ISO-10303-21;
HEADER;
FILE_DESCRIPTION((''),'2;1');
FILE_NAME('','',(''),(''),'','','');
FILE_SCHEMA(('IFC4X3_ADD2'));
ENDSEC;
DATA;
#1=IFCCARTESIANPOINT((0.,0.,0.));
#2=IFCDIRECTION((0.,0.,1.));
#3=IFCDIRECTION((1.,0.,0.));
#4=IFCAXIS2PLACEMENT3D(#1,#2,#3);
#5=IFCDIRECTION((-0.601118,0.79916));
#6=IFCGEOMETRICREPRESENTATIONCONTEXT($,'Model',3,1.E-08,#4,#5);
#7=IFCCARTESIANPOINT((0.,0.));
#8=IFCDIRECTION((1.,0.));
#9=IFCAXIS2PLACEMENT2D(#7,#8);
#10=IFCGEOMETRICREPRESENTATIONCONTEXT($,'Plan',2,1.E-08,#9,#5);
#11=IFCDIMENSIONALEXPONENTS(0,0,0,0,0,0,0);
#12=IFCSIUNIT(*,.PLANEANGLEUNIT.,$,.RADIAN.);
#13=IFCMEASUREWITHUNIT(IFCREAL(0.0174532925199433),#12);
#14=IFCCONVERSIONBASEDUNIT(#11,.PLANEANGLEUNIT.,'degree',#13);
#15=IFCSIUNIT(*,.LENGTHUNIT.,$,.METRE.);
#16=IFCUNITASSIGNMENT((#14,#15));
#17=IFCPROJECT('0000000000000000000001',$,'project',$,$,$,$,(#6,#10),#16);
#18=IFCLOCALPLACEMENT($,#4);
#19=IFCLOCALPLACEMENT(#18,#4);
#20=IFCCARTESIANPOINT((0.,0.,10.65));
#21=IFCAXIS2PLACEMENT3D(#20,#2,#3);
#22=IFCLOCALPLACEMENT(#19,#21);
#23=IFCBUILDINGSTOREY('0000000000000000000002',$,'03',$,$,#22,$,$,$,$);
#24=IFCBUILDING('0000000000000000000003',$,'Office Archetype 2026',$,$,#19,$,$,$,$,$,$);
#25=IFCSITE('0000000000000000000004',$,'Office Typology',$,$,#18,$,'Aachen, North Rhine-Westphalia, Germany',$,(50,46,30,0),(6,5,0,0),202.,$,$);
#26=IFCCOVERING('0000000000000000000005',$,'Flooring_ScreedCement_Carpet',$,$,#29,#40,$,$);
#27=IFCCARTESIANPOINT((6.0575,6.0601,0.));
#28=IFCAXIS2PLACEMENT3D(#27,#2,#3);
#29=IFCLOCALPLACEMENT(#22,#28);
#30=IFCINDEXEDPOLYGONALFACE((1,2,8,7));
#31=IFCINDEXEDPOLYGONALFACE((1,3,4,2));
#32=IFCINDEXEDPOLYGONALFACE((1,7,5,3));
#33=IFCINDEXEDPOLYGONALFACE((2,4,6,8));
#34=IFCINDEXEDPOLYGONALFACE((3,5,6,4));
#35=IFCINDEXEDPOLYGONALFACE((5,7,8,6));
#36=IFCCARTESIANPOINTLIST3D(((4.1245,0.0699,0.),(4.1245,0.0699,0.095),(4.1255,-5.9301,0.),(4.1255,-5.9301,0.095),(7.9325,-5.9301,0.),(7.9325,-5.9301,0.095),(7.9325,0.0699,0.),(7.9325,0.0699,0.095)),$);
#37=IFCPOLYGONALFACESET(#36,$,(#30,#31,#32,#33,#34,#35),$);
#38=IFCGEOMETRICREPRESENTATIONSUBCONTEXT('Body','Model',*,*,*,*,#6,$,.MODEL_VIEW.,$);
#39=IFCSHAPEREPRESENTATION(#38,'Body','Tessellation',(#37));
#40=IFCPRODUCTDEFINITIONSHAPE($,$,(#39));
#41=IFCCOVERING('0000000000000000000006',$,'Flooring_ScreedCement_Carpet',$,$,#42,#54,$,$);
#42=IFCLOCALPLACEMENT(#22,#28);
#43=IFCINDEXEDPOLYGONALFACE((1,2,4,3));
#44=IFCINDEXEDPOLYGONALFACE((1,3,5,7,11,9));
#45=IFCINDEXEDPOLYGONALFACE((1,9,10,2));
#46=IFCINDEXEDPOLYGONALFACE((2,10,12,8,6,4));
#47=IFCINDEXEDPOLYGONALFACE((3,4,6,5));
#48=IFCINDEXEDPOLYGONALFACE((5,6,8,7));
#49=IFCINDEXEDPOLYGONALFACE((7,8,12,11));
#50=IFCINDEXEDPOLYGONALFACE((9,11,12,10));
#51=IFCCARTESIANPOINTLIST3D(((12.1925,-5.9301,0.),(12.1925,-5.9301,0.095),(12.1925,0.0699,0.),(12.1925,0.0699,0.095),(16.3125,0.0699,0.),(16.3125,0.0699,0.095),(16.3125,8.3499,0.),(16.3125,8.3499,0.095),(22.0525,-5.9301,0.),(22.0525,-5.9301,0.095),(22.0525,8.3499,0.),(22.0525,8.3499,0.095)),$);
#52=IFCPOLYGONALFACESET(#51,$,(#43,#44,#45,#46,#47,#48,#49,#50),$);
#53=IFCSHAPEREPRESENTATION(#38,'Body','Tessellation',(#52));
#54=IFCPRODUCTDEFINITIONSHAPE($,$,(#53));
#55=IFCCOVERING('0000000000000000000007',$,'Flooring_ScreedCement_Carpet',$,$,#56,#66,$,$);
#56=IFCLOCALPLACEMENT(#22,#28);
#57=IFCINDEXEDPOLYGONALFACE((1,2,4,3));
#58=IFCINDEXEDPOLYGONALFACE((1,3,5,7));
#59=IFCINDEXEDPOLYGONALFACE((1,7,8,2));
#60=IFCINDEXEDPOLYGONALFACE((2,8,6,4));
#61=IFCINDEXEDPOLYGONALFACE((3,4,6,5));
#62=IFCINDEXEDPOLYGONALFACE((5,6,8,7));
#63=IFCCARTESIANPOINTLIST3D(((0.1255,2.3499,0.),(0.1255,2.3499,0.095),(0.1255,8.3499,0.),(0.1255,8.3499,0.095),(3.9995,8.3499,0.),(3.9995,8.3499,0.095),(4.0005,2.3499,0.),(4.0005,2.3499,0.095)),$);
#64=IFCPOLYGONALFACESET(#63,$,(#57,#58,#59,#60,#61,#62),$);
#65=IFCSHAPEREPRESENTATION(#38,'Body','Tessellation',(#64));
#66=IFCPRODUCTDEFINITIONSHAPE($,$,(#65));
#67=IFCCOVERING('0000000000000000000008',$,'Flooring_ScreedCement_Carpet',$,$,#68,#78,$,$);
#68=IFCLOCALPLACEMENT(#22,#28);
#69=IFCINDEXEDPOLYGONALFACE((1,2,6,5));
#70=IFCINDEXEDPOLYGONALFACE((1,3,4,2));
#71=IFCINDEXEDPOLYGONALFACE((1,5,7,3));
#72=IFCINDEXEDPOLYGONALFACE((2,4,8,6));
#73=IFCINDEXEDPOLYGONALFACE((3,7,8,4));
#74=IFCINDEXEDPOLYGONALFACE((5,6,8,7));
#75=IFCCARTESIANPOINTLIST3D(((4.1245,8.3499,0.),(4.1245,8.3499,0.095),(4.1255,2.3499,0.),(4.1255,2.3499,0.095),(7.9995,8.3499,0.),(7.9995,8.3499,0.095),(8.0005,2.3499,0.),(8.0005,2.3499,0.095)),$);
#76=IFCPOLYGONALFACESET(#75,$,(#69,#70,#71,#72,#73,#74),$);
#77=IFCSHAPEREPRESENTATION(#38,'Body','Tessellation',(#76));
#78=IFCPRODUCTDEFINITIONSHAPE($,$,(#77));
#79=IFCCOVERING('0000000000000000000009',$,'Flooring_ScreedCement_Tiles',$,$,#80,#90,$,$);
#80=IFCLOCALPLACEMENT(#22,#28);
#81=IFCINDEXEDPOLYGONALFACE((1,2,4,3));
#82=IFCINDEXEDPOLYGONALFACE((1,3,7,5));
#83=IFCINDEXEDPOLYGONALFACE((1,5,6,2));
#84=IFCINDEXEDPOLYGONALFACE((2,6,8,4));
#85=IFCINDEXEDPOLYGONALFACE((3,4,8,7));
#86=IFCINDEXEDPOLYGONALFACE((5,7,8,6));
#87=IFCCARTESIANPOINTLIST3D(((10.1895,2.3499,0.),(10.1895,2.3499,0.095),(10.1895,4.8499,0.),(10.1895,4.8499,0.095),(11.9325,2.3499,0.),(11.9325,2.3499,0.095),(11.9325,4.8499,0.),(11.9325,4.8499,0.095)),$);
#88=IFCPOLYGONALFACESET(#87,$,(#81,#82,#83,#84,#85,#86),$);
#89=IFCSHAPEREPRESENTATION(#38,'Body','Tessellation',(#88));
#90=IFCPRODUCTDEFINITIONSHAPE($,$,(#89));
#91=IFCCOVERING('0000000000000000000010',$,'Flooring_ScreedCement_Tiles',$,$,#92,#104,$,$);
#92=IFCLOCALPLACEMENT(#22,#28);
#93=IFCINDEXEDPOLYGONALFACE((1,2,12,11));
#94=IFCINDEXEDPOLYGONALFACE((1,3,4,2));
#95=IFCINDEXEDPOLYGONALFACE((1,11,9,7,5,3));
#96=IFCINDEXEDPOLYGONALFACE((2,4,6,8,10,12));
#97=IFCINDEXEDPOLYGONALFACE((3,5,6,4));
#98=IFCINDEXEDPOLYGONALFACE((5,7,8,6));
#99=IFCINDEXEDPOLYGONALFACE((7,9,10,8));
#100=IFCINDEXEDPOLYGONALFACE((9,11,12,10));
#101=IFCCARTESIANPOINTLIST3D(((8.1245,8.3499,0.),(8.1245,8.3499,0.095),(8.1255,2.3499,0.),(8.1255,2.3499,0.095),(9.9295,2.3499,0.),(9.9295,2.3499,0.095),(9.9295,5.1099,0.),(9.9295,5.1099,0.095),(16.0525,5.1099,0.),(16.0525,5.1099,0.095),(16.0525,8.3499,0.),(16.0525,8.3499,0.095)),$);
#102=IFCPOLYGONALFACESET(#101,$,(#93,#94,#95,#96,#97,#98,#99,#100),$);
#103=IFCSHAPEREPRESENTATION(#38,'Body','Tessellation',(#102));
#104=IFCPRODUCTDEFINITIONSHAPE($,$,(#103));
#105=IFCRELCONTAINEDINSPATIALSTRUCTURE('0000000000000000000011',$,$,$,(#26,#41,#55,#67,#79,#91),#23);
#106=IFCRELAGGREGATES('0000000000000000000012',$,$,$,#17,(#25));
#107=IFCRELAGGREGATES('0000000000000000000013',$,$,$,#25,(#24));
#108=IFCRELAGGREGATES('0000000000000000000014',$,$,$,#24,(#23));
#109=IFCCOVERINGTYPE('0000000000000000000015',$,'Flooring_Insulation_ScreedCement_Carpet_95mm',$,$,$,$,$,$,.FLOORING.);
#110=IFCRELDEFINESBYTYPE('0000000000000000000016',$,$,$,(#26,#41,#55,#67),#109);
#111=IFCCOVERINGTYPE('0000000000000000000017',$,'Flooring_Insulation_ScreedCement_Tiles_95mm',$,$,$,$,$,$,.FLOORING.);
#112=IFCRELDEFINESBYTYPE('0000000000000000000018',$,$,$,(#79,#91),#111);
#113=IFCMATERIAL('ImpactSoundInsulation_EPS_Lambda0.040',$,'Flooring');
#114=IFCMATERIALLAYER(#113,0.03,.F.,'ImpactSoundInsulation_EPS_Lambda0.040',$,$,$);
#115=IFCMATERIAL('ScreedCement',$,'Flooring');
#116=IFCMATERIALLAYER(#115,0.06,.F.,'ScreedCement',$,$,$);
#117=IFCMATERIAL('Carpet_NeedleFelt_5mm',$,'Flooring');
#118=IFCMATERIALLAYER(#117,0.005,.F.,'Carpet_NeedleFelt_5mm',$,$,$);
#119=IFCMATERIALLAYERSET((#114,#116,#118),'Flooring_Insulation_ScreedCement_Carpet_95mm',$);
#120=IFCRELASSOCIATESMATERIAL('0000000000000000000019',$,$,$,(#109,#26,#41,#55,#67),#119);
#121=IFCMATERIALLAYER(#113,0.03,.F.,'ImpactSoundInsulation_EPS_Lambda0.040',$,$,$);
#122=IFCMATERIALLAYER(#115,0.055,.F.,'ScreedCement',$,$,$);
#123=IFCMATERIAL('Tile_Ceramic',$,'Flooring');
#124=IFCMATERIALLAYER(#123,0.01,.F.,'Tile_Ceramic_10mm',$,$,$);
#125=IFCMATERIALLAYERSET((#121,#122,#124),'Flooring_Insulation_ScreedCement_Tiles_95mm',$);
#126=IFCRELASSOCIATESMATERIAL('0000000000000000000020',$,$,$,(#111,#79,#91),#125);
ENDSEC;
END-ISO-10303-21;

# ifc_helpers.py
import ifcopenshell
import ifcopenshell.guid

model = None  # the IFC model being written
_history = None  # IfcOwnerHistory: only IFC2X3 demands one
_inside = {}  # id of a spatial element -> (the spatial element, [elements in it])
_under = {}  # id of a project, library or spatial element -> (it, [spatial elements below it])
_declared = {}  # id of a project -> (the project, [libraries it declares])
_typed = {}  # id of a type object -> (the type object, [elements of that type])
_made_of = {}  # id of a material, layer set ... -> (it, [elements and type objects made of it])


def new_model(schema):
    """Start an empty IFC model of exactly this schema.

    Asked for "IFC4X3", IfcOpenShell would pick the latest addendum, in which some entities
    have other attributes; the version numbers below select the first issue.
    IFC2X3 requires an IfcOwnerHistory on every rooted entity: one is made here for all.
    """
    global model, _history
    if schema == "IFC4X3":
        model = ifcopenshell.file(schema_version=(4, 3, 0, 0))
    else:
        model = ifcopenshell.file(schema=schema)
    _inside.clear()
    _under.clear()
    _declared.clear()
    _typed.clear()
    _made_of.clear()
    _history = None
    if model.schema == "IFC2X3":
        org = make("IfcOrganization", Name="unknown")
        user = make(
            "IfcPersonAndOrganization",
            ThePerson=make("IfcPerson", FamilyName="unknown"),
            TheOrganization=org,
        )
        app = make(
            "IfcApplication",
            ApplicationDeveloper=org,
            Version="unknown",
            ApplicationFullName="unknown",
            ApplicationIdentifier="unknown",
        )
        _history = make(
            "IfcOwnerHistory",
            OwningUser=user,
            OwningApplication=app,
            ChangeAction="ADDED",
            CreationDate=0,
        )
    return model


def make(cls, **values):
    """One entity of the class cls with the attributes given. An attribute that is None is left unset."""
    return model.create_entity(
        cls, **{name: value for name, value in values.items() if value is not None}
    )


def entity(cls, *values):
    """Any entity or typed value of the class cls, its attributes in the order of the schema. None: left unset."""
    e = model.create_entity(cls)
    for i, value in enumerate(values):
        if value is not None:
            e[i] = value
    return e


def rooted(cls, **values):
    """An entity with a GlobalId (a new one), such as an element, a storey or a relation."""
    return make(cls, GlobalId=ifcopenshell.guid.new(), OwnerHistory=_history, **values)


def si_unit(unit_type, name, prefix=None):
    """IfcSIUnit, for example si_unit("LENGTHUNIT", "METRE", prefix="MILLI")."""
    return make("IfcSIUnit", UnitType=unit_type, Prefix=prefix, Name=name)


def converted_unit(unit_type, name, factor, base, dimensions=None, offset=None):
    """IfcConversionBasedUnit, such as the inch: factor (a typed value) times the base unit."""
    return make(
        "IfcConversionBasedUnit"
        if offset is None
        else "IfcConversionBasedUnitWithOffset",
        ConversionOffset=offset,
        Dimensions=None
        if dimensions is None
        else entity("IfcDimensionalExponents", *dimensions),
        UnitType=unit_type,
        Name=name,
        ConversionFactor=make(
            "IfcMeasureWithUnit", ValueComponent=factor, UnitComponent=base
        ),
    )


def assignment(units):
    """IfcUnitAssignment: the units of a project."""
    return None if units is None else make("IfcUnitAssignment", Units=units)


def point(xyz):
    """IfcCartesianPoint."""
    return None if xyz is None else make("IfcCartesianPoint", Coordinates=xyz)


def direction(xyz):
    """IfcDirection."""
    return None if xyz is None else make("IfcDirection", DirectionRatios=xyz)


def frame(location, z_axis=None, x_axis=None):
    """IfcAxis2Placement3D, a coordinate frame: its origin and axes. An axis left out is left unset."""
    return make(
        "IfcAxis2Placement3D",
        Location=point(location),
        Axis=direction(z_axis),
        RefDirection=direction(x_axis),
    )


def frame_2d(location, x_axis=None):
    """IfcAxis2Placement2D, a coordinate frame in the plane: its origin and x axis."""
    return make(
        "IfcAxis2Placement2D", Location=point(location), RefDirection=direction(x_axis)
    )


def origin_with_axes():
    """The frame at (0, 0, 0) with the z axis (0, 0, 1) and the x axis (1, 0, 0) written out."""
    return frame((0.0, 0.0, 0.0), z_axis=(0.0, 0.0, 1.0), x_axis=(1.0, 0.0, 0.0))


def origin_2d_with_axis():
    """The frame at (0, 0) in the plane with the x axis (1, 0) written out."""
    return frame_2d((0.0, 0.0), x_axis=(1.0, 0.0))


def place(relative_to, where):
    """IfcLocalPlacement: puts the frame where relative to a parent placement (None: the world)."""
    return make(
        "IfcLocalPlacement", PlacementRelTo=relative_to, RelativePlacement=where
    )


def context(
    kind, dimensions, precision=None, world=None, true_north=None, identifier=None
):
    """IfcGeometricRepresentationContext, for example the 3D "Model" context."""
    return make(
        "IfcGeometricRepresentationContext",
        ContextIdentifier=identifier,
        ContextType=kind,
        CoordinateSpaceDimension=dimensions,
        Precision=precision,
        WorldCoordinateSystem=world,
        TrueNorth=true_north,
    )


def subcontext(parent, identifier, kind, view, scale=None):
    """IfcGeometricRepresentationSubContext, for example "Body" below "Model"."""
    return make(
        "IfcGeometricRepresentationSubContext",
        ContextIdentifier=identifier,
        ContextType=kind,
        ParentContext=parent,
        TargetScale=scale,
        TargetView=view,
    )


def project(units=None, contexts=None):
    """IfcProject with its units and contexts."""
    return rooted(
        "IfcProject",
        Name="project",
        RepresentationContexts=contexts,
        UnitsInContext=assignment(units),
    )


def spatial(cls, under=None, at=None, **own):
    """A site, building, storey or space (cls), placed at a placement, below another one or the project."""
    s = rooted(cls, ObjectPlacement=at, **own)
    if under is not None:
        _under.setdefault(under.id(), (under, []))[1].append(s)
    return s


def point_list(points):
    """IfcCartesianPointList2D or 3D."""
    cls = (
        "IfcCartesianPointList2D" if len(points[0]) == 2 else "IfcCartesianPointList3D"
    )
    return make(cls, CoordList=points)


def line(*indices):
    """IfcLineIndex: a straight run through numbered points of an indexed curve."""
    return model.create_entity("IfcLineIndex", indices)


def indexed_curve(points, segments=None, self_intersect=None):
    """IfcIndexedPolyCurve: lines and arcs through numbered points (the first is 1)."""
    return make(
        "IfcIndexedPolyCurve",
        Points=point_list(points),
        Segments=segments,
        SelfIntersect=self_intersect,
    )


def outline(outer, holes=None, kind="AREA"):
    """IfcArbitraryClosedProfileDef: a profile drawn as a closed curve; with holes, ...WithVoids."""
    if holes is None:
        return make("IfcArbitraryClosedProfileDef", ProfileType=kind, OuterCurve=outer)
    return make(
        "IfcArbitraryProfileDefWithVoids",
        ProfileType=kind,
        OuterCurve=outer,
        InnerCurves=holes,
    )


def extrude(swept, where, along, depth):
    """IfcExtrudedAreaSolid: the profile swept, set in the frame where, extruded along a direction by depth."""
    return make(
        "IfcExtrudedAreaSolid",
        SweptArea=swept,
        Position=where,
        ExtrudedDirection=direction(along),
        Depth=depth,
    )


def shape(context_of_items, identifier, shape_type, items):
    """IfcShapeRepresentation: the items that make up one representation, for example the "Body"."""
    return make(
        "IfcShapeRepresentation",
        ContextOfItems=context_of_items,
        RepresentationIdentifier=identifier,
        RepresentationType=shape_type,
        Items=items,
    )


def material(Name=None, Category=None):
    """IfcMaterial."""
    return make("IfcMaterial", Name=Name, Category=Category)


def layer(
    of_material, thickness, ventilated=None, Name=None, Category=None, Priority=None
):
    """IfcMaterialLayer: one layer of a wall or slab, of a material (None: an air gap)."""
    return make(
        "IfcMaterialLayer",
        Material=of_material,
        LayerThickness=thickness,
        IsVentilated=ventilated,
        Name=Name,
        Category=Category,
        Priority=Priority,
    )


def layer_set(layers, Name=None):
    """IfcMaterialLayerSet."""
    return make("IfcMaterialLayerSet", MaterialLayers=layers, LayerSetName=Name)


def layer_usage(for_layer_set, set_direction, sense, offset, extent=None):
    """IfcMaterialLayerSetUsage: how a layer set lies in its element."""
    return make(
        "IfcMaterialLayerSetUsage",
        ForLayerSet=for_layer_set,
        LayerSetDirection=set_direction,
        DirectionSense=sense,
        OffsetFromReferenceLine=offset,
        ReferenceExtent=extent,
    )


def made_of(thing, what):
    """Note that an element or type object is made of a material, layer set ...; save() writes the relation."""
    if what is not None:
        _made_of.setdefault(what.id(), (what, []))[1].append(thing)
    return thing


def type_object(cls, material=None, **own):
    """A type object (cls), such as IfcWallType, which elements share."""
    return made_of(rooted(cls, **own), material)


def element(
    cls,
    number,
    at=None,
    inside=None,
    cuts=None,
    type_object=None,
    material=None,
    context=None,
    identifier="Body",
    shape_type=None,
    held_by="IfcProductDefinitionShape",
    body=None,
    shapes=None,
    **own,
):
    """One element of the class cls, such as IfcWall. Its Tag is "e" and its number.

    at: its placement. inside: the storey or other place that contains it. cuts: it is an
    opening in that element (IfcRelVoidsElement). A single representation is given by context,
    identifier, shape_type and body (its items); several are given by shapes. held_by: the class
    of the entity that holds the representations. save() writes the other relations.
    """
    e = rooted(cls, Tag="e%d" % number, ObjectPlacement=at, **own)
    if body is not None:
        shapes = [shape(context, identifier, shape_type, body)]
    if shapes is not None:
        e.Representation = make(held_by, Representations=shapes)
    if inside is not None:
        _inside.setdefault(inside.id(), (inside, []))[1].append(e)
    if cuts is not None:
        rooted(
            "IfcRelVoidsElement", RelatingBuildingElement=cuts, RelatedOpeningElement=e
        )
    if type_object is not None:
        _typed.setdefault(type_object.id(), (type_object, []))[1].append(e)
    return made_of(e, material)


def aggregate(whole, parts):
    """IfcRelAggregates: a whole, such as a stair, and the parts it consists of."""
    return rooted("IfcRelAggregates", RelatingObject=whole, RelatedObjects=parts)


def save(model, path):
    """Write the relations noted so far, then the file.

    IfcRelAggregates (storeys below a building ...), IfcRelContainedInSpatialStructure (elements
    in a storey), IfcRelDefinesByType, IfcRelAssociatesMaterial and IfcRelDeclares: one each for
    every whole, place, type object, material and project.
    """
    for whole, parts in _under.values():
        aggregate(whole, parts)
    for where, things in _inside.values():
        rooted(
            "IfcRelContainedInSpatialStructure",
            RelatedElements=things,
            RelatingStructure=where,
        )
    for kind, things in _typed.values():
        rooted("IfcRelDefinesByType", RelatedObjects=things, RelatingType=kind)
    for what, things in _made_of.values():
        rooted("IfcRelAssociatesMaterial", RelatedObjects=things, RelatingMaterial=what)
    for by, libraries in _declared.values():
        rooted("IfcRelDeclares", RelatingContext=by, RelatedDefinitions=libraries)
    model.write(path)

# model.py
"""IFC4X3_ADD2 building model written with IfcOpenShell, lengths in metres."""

from ifc_helpers import new_model, entity, si_unit, converted_unit, direction, frame, origin_with_axes, origin_2d_with_axis, place, context, subcontext, project, spatial, line, indexed_curve, outline, extrude, material, layer, layer_set, layer_usage, type_object, element, save


model = new_model("IFC4X3_ADD2")

# Units and contexts
model_context = context("Model", 3, precision=1e-08, world=origin_with_axes(), true_north=direction((-0.601118, 0.79916)))
plan_context = context("Plan", 2, precision=1e-08, world=origin_2d_with_axis(), true_north=direction((-0.601118, 0.79916)))
body_context = subcontext(model_context, "Body", "Model", "MODEL_VIEW")
ifc_project = project(units=[converted_unit("PLANEANGLEUNIT", "degree", entity("IfcReal", 0.0174532925199433), si_unit("PLANEANGLEUNIT", "RADIAN"), dimensions=[0, 0, 0, 0, 0, 0, 0]), si_unit("LENGTHUNIT", "METRE")], contexts=[model_context, plan_context])

# Site, building, storey
site_placement = place(None, origin_with_axes())
site = spatial("IfcSite", under=ifc_project, at=site_placement, Name="Office Typology", LongName="Aachen, North Rhine-Westphalia, Germany", RefLatitude=(50, 46, 30, 0), RefLongitude=(6, 5, 0, 0), RefElevation=202.0)
building_placement = place(site_placement, origin_with_axes())
building = spatial("IfcBuilding", under=site, at=building_placement, Name="Office Archetype 2026")
storey_placement = place(building_placement, frame((0.0, 0.0, 10.65), z_axis=(0.0, 0.0, 1.0), x_axis=(1.0, 0.0, 0.0)))
storey = spatial("IfcBuildingStorey", under=building, at=storey_placement, Name="03")

# Coverings
ifc_material_1 = material(Name="ImpactSoundInsulation_EPS_Lambda0.040", Category="Flooring")
ifc_layer_1 = layer(ifc_material_1, 0.03, ventilated=False, Name="ImpactSoundInsulation_EPS_Lambda0.040")
ifc_material_2 = material(Name="ScreedCement", Category="Flooring")
ifc_layer_2 = layer(ifc_material_2, 0.06, ventilated=False, Name="ScreedCement")
ifc_material_3 = material(Name="Carpet_NeedleFelt_5mm", Category="Flooring")
ifc_layer_3 = layer(ifc_material_3, 0.005, ventilated=False, Name="Carpet_NeedleFelt_5mm")
ifc_layer_set_1 = layer_set([ifc_layer_1, ifc_layer_2, ifc_layer_3], Name="Flooring_Insulation_ScreedCement_Carpet_95mm")
ifc_layer_usage_1 = layer_usage(ifc_layer_set_1, "AXIS3", "POSITIVE", 0.0)
covering_type_1 = type_object("IfcCoveringType", Name="Flooring_Insulation_ScreedCement_Carpet_95mm", PredefinedType="FLOORING", material=ifc_layer_set_1)
covering_1_placement = place(storey_placement, frame((6.0575, 6.0601, 0.0), z_axis=(0.0, 0.0, 1.0), x_axis=(1.0, 0.0, 0.0)))
element("IfcCovering", 1, at=covering_1_placement, inside=storey, type_object=covering_type_1, material=ifc_layer_usage_1, Name="Flooring_ScreedCement_Carpet", context=body_context, shape_type="SweptSolid", body=[
    extrude(outline(indexed_curve([(4.1245, 0.0699), (7.9325, 0.0699), (7.9325, -5.9301), (4.1255, -5.9301)], segments=[line(1, 2, 3, 4, 1)])), origin_with_axes(), (0.0, 0.0, 1.0), 0.095),
])
ifc_layer_usage_2 = layer_usage(ifc_layer_set_1, "AXIS3", "POSITIVE", 0.0)
covering_2_placement = place(storey_placement, frame((6.0575, 6.0601, 0.0), z_axis=(0.0, 0.0, 1.0), x_axis=(1.0, 0.0, 0.0)))
element("IfcCovering", 2, at=covering_2_placement, inside=storey, type_object=covering_type_1, material=ifc_layer_usage_2, Name="Flooring_ScreedCement_Carpet", context=body_context, shape_type="SweptSolid", body=[
    extrude(outline(indexed_curve([(16.3125, 8.3499), (22.0525, 8.3499), (22.0525, -5.9301), (12.1925, -5.9301), (12.1925, 0.0699), (16.3125, 0.0699)], segments=[line(1, 2, 3, 4, 5, 6, 1)])), origin_with_axes(), (0.0, 0.0, 1.0), 0.095),
])
ifc_layer_usage_3 = layer_usage(ifc_layer_set_1, "AXIS3", "POSITIVE", 0.0)
covering_3_placement = place(storey_placement, frame((6.0575, 6.0601, 0.0), z_axis=(0.0, 0.0, 1.0), x_axis=(1.0, 0.0, 0.0)))
element("IfcCovering", 3, at=covering_3_placement, inside=storey, type_object=covering_type_1, material=ifc_layer_usage_3, Name="Flooring_ScreedCement_Carpet", context=body_context, shape_type="SweptSolid", body=[
    extrude(outline(indexed_curve([(0.1255, 2.3499), (0.1255, 8.3499), (3.9995, 8.3499), (4.0005, 2.3499)], segments=[line(1, 2, 3, 4, 1)])), origin_with_axes(), (0.0, 0.0, 1.0), 0.095),
])
ifc_layer_usage_4 = layer_usage(ifc_layer_set_1, "AXIS3", "POSITIVE", 0.0)
covering_4_placement = place(storey_placement, frame((6.0575, 6.0601, 0.0), z_axis=(0.0, 0.0, 1.0), x_axis=(1.0, 0.0, 0.0)))
element("IfcCovering", 4, at=covering_4_placement, inside=storey, type_object=covering_type_1, material=ifc_layer_usage_4, Name="Flooring_ScreedCement_Carpet", context=body_context, shape_type="SweptSolid", body=[
    extrude(outline(indexed_curve([(4.1255, 2.3499), (4.1245, 8.3499), (7.9995, 8.3499), (8.0005, 2.3499)], segments=[line(1, 2, 3, 4, 1)])), origin_with_axes(), (0.0, 0.0, 1.0), 0.095),
])
ifc_layer_4 = layer(ifc_material_1, 0.03, ventilated=False, Name="ImpactSoundInsulation_EPS_Lambda0.040")
ifc_layer_5 = layer(ifc_material_2, 0.055, ventilated=False, Name="ScreedCement")
ifc_material_4 = material(Name="Tile_Ceramic", Category="Flooring")
ifc_layer_6 = layer(ifc_material_4, 0.01, ventilated=False, Name="Tile_Ceramic_10mm")
ifc_layer_set_2 = layer_set([ifc_layer_4, ifc_layer_5, ifc_layer_6], Name="Flooring_Insulation_ScreedCement_Tiles_95mm")
ifc_layer_usage_5 = layer_usage(ifc_layer_set_2, "AXIS3", "POSITIVE", 0.0)
covering_type_2 = type_object("IfcCoveringType", Name="Flooring_Insulation_ScreedCement_Tiles_95mm", PredefinedType="FLOORING", material=ifc_layer_set_2)
covering_5_placement = place(storey_placement, frame((6.0575, 6.0601, 0.0), z_axis=(0.0, 0.0, 1.0), x_axis=(1.0, 0.0, 0.0)))
element("IfcCovering", 5, at=covering_5_placement, inside=storey, type_object=covering_type_2, material=ifc_layer_usage_5, Name="Flooring_ScreedCement_Tiles", context=body_context, shape_type="SweptSolid", body=[
    extrude(outline(indexed_curve([(11.9325, 4.8499), (11.9325, 2.3499), (10.1895, 2.3499), (10.1895, 4.8499)], segments=[line(1, 2, 3, 4, 1)])), None, (0.0, 0.0, 1.0), 0.095),
])
ifc_layer_usage_6 = layer_usage(ifc_layer_set_2, "AXIS3", "POSITIVE", 0.0)
covering_6_placement = place(storey_placement, frame((6.0575, 6.0601, 0.0), z_axis=(0.0, 0.0, 1.0), x_axis=(1.0, 0.0, 0.0)))
element("IfcCovering", 6, at=covering_6_placement, inside=storey, type_object=covering_type_2, material=ifc_layer_usage_6, Name="Flooring_ScreedCement_Tiles", context=body_context, shape_type="SweptSolid", body=[
    extrude(outline(indexed_curve([(9.9295, 5.1099), (9.9295, 2.3499), (8.1255, 2.3499), (8.1245, 8.3499), (16.0525, 8.3499), (16.0525, 5.1099)], segments=[line(1, 2, 3, 4, 5, 6, 1)])), None, (0.0, 0.0, 1.0), 0.095),
])

save(model, "model.ifc")
